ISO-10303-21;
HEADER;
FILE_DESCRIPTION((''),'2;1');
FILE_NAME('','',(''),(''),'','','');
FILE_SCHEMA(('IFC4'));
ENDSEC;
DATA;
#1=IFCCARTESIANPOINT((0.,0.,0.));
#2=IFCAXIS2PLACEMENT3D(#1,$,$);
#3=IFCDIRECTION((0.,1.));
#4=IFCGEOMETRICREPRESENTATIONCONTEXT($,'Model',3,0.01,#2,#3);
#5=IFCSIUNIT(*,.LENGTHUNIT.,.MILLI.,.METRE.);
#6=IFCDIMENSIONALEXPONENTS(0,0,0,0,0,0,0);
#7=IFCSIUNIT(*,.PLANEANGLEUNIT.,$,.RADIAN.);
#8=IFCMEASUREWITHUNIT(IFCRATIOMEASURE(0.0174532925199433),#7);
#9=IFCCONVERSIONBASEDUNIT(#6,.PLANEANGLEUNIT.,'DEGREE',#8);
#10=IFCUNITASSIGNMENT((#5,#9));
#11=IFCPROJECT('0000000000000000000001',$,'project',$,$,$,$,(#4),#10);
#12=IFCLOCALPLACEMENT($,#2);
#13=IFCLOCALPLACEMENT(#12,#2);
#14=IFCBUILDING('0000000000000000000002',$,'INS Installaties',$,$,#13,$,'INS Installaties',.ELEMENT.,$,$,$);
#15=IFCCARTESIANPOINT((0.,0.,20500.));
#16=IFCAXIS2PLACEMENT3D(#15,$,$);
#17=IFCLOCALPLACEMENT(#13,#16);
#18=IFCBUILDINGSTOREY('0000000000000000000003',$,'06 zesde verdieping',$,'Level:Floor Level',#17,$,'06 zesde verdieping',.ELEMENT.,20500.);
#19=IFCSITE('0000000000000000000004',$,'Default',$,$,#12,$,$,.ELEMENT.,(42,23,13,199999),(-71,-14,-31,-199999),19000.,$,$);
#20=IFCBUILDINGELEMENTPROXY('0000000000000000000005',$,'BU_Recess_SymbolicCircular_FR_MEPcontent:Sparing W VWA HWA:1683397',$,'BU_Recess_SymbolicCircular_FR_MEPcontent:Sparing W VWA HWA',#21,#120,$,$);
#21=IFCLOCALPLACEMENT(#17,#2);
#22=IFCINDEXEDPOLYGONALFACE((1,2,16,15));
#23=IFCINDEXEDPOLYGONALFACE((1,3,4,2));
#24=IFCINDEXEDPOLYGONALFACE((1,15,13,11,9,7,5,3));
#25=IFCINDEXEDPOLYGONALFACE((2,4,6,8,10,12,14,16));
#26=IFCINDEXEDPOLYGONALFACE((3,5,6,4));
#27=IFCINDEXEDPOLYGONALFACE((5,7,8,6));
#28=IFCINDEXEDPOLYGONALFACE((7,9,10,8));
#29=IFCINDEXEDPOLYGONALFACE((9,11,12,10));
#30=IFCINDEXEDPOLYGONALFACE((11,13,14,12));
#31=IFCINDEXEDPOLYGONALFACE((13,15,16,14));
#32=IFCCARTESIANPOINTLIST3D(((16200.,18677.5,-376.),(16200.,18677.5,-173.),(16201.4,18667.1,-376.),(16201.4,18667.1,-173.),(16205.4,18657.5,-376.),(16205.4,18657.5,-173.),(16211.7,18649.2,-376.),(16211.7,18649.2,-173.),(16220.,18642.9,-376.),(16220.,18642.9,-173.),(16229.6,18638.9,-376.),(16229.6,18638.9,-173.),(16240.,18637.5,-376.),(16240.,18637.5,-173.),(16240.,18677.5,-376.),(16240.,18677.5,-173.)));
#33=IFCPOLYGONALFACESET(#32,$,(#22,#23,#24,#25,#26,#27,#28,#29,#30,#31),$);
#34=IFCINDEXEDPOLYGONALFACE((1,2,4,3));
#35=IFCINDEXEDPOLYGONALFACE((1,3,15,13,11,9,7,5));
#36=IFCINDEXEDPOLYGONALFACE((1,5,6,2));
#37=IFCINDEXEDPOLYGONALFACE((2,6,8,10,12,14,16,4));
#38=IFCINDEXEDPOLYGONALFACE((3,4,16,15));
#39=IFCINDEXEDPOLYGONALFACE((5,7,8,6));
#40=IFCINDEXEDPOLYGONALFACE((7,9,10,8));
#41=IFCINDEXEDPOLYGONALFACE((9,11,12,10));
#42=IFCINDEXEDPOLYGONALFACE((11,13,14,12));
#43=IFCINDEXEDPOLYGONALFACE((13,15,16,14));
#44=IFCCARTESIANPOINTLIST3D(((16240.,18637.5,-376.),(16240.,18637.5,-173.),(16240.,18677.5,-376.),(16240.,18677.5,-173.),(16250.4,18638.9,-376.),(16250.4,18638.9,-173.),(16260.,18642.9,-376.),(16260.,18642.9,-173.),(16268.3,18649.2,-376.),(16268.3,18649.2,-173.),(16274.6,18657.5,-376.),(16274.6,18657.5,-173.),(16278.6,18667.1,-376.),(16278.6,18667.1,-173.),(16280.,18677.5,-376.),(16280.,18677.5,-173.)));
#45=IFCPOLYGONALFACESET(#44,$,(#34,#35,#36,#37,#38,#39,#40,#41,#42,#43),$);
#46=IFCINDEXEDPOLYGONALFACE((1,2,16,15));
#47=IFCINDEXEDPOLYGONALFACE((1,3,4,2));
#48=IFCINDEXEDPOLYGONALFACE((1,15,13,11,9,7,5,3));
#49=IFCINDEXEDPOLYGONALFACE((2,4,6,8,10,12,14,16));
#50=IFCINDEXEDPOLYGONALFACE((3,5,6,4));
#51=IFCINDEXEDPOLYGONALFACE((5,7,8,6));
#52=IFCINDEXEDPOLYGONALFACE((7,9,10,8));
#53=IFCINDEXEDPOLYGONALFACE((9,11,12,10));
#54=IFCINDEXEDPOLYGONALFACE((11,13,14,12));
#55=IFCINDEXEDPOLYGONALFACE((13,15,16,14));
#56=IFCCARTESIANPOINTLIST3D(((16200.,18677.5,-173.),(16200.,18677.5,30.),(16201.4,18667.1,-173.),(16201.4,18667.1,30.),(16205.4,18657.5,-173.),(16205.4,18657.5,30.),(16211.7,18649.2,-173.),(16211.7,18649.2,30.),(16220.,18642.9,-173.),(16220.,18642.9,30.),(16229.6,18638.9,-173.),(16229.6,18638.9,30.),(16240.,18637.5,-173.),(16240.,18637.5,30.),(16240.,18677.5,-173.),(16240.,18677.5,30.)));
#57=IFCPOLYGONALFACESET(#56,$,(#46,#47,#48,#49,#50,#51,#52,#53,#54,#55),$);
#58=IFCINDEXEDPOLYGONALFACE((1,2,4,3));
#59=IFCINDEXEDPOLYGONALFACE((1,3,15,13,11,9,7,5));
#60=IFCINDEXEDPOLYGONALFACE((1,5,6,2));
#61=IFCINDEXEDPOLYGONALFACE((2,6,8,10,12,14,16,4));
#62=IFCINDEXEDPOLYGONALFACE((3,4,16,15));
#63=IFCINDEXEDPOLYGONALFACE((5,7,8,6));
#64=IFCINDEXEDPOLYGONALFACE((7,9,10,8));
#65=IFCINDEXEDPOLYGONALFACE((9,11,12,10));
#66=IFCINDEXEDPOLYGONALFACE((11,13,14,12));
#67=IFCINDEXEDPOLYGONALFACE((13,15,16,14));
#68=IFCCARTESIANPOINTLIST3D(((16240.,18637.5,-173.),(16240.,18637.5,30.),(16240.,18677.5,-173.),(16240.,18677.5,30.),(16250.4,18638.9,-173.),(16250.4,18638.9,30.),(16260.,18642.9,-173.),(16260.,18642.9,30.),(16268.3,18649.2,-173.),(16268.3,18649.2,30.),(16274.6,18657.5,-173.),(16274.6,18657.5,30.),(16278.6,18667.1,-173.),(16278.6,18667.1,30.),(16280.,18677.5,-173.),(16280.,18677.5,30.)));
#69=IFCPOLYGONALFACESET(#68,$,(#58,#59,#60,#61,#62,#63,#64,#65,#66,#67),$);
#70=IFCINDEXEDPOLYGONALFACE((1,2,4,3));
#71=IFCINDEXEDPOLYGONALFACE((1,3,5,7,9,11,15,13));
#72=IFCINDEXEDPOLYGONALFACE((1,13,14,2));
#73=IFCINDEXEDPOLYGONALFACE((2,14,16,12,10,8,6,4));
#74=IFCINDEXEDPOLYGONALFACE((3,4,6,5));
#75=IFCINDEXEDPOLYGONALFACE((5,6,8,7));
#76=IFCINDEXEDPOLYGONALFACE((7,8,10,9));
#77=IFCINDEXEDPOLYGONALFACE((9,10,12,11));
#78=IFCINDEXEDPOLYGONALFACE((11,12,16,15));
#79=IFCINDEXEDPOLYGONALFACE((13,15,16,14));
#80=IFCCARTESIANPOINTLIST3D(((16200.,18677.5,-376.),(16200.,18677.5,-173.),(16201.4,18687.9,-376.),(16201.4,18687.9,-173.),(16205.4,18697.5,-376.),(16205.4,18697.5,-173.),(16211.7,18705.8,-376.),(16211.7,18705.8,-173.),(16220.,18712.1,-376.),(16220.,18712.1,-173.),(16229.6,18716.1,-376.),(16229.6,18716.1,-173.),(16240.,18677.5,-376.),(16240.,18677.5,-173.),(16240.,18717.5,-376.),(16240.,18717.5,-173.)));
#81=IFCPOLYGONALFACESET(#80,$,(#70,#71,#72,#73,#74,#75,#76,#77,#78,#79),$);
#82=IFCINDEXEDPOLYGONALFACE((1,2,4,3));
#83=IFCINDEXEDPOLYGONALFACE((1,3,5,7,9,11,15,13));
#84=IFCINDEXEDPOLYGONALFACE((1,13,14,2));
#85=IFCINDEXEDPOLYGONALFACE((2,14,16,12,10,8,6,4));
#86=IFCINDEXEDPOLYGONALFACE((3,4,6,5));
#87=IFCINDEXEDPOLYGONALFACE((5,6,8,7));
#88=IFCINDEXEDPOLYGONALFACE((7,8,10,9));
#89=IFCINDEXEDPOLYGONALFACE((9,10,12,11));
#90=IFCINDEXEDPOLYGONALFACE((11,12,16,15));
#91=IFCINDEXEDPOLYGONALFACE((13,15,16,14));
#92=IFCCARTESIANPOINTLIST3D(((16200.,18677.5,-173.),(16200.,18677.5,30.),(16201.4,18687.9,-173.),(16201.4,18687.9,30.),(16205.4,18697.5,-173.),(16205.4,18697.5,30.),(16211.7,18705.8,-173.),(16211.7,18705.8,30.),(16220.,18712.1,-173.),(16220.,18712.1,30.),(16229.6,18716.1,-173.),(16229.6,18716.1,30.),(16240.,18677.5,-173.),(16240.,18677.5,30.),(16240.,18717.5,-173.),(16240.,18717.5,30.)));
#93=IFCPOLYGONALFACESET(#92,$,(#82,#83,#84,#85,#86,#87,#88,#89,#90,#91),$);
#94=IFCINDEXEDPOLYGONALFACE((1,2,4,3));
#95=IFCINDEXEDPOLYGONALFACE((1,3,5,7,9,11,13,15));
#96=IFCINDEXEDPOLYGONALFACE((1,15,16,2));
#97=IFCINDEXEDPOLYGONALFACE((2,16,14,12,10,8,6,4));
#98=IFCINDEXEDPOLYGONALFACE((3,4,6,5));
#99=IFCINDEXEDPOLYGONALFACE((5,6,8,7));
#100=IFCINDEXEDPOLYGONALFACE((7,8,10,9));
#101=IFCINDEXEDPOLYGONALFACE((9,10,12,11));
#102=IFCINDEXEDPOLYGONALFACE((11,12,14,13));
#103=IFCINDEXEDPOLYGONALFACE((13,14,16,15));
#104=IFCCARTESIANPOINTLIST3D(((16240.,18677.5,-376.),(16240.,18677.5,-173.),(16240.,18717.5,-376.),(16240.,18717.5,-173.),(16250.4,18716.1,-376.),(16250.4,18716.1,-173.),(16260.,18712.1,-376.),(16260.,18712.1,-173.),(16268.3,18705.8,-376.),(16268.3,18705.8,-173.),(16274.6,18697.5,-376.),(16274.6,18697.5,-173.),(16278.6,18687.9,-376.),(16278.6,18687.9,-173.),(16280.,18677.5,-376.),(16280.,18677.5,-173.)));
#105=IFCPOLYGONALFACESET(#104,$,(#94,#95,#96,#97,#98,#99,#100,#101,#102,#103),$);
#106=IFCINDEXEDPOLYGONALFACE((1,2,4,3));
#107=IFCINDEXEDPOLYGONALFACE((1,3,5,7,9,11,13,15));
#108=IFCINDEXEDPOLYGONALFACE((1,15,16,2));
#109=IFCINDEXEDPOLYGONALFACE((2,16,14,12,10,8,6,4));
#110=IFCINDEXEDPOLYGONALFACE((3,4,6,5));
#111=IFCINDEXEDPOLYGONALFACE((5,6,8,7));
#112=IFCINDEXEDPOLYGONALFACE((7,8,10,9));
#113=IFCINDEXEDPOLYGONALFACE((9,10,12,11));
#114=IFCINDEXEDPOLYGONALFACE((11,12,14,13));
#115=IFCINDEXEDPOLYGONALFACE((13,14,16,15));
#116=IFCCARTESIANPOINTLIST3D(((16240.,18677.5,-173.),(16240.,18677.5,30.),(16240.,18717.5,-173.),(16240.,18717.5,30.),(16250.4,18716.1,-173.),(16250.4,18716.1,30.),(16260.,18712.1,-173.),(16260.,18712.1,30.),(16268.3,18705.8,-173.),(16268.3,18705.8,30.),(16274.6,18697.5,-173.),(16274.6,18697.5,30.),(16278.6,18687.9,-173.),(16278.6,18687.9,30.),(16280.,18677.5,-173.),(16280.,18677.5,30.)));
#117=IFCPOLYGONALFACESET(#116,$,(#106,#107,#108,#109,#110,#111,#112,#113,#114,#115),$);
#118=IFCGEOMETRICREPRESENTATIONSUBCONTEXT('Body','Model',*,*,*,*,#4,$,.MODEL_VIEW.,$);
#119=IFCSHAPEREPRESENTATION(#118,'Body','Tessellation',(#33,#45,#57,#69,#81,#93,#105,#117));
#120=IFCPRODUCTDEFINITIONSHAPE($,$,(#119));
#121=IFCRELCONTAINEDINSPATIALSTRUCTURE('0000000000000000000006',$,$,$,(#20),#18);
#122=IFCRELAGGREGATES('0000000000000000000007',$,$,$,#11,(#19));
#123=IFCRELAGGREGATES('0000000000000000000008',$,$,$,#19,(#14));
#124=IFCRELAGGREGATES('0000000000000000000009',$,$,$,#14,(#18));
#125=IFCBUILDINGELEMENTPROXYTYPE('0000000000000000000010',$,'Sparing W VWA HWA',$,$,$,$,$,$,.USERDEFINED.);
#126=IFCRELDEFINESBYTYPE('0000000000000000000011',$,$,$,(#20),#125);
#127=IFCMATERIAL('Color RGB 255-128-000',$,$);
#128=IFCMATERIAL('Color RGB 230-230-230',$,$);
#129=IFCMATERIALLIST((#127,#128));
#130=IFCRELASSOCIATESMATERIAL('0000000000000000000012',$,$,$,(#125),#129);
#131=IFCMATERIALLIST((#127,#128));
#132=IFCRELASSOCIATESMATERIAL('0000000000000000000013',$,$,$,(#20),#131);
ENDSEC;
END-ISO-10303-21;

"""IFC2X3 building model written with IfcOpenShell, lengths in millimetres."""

from ifc_helpers import new_model, entity, si_unit, converted_unit, direction, frame, frame_2d, origin, place, context, subcontext, project, spatial, polyline, circle_curve, parameter, trimmed, segment, composite_curve, outline, extrude, source, transform, mapped, material, material_list, type_object, type_shapes, element, save


model = new_model("IFC2X3")

# Units and contexts
model_context = context("Model", 3, precision=0.01, world=origin(), true_north=direction((0.0, 1.0)))
body_context = subcontext(model_context, "Body", "Model", "MODEL_VIEW")
ifc_project = project(units=[si_unit("LENGTHUNIT", "METRE", prefix="MILLI"), converted_unit("PLANEANGLEUNIT", "DEGREE", entity("IfcRatioMeasure", 0.0174532925199433), si_unit("PLANEANGLEUNIT", "RADIAN"), dimensions=[0, 0, 0, 0, 0, 0, 0])], contexts=[model_context])

# Site, building, storey
site_placement = place(None, origin())
site = spatial("IfcSite", under=ifc_project, at=site_placement, Name="Default", CompositionType="ELEMENT", RefLatitude=(42, 23, 13, 199999), RefLongitude=(-71, -14, -31, -199999), RefElevation=19000.0)
building_placement = place(site_placement, origin())
building = spatial("IfcBuilding", under=site, at=building_placement, Name="INS Installaties", LongName="INS Installaties", CompositionType="ELEMENT")
storey_placement = place(building_placement, frame((0.0, 0.0, 20500.0)))
storey = spatial("IfcBuildingStorey", under=building, at=storey_placement, Name="06 zesde verdieping", ObjectType="Level:Floor Level", LongName="06 zesde verdieping", CompositionType="ELEMENT", Elevation=20500.0)

# Building element proxy
ifc_material_1 = material(Name="Color RGB 255-128-000")
ifc_material_2 = material(Name="Color RGB 230-230-230")
ifc_material_list_1 = material_list([ifc_material_1, ifc_material_2])
building_element_proxy_type_1 = type_object("IfcBuildingElementProxyType", Name="Sparing W VWA HWA", PredefinedType="USERDEFINED", material=ifc_material_list_1)
shared_shape_1 = source(origin(), body_context, "Body", "SweptSolid", [
    extrude(outline(composite_curve([segment(trimmed(circle_curve(frame_2d((13.3, 13.3), x_axis=(1.0, 0.0)), 40.0), [parameter(180.0)], [parameter(270.0)], True, "PARAMETER"), True, "CONTINUOUS"), segment(polyline([(13.3, -26.7), (13.3, 13.3)]), True, "CONTINUOUS"), segment(polyline([(13.3, 13.3), (-26.7, 13.3)]), True, "CONTINUOUS")], self_intersect=False)), frame((13.3, 13.3, -403.0), z_axis=(0.0, 0.0, 1.0), x_axis=(-1.0, 0.0, 0.0)), (0.0, 0.0, 1.0), 203.0),
    extrude(outline(composite_curve([segment(polyline([(-26.7, -13.3), (13.3, -13.3)]), True, "CONTINUOUS"), segment(polyline([(13.3, -13.3), (13.3, 26.7)]), True, "CONTINUOUS"), segment(trimmed(circle_curve(frame_2d((13.3, -13.3), x_axis=(1.0, 0.0)), 40.0), [parameter(90.0)], [parameter(180.0)], True, "PARAMETER"), True, "CONTINUOUS")], self_intersect=False)), frame((-13.3, 13.3, -403.0)), (0.0, 0.0, 1.0), 203.0),
    extrude(outline(composite_curve([segment(trimmed(circle_curve(frame_2d((13.3, 13.3), x_axis=(1.0, 0.0)), 40.0), [parameter(180.0)], [parameter(270.0)], True, "PARAMETER"), True, "CONTINUOUS"), segment(polyline([(13.3, -26.7), (13.3, 13.3)]), True, "CONTINUOUS"), segment(polyline([(13.3, 13.3), (-26.7, 13.3)]), True, "CONTINUOUS")], self_intersect=False)), frame((13.3, 13.3, -200.0), z_axis=(0.0, 0.0, 1.0), x_axis=(-1.0, 0.0, 0.0)), (0.0, 0.0, 1.0), 203.0),
    extrude(outline(composite_curve([segment(polyline([(-26.7, -13.3), (13.3, -13.3)]), True, "CONTINUOUS"), segment(polyline([(13.3, -13.3), (13.3, 26.7)]), True, "CONTINUOUS"), segment(trimmed(circle_curve(frame_2d((13.3, -13.3), x_axis=(1.0, 0.0)), 40.0), [parameter(90.0)], [parameter(180.0)], True, "PARAMETER"), True, "CONTINUOUS")], self_intersect=False)), frame((-13.3, 13.3, -200.0)), (0.0, 0.0, 1.0), 203.0),
    extrude(outline(composite_curve([segment(polyline([(-26.7, -13.3), (13.3, -13.3)]), True, "CONTINUOUS"), segment(polyline([(13.3, -13.3), (13.3, 26.7)]), True, "CONTINUOUS"), segment(trimmed(circle_curve(frame_2d((13.3, -13.3), x_axis=(1.0, 0.0)), 40.0), [parameter(90.0)], [parameter(180.0)], True, "PARAMETER"), True, "CONTINUOUS")], self_intersect=False)), frame((13.3, -13.3, -403.0), z_axis=(0.0, 0.0, 1.0), x_axis=(-1.0, 0.0, 0.0)), (0.0, 0.0, 1.0), 203.0),
    extrude(outline(composite_curve([segment(polyline([(-26.7, -13.3), (13.3, -13.3)]), True, "CONTINUOUS"), segment(polyline([(13.3, -13.3), (13.3, 26.7)]), True, "CONTINUOUS"), segment(trimmed(circle_curve(frame_2d((13.3, -13.3), x_axis=(1.0, 0.0)), 40.0), [parameter(90.0)], [parameter(180.0)], True, "PARAMETER"), True, "CONTINUOUS")], self_intersect=False)), frame((13.3, -13.3, -200.0), z_axis=(0.0, 0.0, 1.0), x_axis=(-1.0, 0.0, 0.0)), (0.0, 0.0, 1.0), 203.0),
    extrude(outline(composite_curve([segment(trimmed(circle_curve(frame_2d((13.3, 13.3), x_axis=(1.0, 0.0)), 40.0), [parameter(180.0)], [parameter(270.0)], True, "PARAMETER"), True, "CONTINUOUS"), segment(polyline([(13.3, -26.7), (13.3, 13.3)]), True, "CONTINUOUS"), segment(polyline([(13.3, 13.3), (-26.7, 13.3)]), True, "CONTINUOUS")], self_intersect=False)), frame((-13.3, -13.3, -403.0)), (0.0, 0.0, 1.0), 203.0),
    extrude(outline(composite_curve([segment(trimmed(circle_curve(frame_2d((13.3, 13.3), x_axis=(1.0, 0.0)), 40.0), [parameter(180.0)], [parameter(270.0)], True, "PARAMETER"), True, "CONTINUOUS"), segment(polyline([(13.3, -26.7), (13.3, 13.3)]), True, "CONTINUOUS"), segment(polyline([(13.3, 13.3), (-26.7, 13.3)]), True, "CONTINUOUS")], self_intersect=False)), frame((-13.3, -13.3, -200.0)), (0.0, 0.0, 1.0), 203.0),
])
type_shapes(building_element_proxy_type_1, [shared_shape_1])
ifc_material_list_2 = material_list([ifc_material_1, ifc_material_2])
proxy_1_placement = place(storey_placement, frame((16240.0, 18677.5, 27.0), z_axis=(0.0, 0.0, 1.0), x_axis=(-1.0, 0.0, 0.0)))
element("IfcBuildingElementProxy", 1, at=proxy_1_placement, inside=storey, type_object=building_element_proxy_type_1, material=ifc_material_list_2, Name="BU_Recess_SymbolicCircular_FR_MEPcontent:Sparing W VWA HWA:1683397", ObjectType="BU_Recess_SymbolicCircular_FR_MEPcontent:Sparing W VWA HWA", context=body_context, shape_type="MappedRepresentation", body=[
    mapped(shared_shape_1, transform((0.0, 0.0, 0.0), scale=1.0)),
])

save(model, "model.ifc")
